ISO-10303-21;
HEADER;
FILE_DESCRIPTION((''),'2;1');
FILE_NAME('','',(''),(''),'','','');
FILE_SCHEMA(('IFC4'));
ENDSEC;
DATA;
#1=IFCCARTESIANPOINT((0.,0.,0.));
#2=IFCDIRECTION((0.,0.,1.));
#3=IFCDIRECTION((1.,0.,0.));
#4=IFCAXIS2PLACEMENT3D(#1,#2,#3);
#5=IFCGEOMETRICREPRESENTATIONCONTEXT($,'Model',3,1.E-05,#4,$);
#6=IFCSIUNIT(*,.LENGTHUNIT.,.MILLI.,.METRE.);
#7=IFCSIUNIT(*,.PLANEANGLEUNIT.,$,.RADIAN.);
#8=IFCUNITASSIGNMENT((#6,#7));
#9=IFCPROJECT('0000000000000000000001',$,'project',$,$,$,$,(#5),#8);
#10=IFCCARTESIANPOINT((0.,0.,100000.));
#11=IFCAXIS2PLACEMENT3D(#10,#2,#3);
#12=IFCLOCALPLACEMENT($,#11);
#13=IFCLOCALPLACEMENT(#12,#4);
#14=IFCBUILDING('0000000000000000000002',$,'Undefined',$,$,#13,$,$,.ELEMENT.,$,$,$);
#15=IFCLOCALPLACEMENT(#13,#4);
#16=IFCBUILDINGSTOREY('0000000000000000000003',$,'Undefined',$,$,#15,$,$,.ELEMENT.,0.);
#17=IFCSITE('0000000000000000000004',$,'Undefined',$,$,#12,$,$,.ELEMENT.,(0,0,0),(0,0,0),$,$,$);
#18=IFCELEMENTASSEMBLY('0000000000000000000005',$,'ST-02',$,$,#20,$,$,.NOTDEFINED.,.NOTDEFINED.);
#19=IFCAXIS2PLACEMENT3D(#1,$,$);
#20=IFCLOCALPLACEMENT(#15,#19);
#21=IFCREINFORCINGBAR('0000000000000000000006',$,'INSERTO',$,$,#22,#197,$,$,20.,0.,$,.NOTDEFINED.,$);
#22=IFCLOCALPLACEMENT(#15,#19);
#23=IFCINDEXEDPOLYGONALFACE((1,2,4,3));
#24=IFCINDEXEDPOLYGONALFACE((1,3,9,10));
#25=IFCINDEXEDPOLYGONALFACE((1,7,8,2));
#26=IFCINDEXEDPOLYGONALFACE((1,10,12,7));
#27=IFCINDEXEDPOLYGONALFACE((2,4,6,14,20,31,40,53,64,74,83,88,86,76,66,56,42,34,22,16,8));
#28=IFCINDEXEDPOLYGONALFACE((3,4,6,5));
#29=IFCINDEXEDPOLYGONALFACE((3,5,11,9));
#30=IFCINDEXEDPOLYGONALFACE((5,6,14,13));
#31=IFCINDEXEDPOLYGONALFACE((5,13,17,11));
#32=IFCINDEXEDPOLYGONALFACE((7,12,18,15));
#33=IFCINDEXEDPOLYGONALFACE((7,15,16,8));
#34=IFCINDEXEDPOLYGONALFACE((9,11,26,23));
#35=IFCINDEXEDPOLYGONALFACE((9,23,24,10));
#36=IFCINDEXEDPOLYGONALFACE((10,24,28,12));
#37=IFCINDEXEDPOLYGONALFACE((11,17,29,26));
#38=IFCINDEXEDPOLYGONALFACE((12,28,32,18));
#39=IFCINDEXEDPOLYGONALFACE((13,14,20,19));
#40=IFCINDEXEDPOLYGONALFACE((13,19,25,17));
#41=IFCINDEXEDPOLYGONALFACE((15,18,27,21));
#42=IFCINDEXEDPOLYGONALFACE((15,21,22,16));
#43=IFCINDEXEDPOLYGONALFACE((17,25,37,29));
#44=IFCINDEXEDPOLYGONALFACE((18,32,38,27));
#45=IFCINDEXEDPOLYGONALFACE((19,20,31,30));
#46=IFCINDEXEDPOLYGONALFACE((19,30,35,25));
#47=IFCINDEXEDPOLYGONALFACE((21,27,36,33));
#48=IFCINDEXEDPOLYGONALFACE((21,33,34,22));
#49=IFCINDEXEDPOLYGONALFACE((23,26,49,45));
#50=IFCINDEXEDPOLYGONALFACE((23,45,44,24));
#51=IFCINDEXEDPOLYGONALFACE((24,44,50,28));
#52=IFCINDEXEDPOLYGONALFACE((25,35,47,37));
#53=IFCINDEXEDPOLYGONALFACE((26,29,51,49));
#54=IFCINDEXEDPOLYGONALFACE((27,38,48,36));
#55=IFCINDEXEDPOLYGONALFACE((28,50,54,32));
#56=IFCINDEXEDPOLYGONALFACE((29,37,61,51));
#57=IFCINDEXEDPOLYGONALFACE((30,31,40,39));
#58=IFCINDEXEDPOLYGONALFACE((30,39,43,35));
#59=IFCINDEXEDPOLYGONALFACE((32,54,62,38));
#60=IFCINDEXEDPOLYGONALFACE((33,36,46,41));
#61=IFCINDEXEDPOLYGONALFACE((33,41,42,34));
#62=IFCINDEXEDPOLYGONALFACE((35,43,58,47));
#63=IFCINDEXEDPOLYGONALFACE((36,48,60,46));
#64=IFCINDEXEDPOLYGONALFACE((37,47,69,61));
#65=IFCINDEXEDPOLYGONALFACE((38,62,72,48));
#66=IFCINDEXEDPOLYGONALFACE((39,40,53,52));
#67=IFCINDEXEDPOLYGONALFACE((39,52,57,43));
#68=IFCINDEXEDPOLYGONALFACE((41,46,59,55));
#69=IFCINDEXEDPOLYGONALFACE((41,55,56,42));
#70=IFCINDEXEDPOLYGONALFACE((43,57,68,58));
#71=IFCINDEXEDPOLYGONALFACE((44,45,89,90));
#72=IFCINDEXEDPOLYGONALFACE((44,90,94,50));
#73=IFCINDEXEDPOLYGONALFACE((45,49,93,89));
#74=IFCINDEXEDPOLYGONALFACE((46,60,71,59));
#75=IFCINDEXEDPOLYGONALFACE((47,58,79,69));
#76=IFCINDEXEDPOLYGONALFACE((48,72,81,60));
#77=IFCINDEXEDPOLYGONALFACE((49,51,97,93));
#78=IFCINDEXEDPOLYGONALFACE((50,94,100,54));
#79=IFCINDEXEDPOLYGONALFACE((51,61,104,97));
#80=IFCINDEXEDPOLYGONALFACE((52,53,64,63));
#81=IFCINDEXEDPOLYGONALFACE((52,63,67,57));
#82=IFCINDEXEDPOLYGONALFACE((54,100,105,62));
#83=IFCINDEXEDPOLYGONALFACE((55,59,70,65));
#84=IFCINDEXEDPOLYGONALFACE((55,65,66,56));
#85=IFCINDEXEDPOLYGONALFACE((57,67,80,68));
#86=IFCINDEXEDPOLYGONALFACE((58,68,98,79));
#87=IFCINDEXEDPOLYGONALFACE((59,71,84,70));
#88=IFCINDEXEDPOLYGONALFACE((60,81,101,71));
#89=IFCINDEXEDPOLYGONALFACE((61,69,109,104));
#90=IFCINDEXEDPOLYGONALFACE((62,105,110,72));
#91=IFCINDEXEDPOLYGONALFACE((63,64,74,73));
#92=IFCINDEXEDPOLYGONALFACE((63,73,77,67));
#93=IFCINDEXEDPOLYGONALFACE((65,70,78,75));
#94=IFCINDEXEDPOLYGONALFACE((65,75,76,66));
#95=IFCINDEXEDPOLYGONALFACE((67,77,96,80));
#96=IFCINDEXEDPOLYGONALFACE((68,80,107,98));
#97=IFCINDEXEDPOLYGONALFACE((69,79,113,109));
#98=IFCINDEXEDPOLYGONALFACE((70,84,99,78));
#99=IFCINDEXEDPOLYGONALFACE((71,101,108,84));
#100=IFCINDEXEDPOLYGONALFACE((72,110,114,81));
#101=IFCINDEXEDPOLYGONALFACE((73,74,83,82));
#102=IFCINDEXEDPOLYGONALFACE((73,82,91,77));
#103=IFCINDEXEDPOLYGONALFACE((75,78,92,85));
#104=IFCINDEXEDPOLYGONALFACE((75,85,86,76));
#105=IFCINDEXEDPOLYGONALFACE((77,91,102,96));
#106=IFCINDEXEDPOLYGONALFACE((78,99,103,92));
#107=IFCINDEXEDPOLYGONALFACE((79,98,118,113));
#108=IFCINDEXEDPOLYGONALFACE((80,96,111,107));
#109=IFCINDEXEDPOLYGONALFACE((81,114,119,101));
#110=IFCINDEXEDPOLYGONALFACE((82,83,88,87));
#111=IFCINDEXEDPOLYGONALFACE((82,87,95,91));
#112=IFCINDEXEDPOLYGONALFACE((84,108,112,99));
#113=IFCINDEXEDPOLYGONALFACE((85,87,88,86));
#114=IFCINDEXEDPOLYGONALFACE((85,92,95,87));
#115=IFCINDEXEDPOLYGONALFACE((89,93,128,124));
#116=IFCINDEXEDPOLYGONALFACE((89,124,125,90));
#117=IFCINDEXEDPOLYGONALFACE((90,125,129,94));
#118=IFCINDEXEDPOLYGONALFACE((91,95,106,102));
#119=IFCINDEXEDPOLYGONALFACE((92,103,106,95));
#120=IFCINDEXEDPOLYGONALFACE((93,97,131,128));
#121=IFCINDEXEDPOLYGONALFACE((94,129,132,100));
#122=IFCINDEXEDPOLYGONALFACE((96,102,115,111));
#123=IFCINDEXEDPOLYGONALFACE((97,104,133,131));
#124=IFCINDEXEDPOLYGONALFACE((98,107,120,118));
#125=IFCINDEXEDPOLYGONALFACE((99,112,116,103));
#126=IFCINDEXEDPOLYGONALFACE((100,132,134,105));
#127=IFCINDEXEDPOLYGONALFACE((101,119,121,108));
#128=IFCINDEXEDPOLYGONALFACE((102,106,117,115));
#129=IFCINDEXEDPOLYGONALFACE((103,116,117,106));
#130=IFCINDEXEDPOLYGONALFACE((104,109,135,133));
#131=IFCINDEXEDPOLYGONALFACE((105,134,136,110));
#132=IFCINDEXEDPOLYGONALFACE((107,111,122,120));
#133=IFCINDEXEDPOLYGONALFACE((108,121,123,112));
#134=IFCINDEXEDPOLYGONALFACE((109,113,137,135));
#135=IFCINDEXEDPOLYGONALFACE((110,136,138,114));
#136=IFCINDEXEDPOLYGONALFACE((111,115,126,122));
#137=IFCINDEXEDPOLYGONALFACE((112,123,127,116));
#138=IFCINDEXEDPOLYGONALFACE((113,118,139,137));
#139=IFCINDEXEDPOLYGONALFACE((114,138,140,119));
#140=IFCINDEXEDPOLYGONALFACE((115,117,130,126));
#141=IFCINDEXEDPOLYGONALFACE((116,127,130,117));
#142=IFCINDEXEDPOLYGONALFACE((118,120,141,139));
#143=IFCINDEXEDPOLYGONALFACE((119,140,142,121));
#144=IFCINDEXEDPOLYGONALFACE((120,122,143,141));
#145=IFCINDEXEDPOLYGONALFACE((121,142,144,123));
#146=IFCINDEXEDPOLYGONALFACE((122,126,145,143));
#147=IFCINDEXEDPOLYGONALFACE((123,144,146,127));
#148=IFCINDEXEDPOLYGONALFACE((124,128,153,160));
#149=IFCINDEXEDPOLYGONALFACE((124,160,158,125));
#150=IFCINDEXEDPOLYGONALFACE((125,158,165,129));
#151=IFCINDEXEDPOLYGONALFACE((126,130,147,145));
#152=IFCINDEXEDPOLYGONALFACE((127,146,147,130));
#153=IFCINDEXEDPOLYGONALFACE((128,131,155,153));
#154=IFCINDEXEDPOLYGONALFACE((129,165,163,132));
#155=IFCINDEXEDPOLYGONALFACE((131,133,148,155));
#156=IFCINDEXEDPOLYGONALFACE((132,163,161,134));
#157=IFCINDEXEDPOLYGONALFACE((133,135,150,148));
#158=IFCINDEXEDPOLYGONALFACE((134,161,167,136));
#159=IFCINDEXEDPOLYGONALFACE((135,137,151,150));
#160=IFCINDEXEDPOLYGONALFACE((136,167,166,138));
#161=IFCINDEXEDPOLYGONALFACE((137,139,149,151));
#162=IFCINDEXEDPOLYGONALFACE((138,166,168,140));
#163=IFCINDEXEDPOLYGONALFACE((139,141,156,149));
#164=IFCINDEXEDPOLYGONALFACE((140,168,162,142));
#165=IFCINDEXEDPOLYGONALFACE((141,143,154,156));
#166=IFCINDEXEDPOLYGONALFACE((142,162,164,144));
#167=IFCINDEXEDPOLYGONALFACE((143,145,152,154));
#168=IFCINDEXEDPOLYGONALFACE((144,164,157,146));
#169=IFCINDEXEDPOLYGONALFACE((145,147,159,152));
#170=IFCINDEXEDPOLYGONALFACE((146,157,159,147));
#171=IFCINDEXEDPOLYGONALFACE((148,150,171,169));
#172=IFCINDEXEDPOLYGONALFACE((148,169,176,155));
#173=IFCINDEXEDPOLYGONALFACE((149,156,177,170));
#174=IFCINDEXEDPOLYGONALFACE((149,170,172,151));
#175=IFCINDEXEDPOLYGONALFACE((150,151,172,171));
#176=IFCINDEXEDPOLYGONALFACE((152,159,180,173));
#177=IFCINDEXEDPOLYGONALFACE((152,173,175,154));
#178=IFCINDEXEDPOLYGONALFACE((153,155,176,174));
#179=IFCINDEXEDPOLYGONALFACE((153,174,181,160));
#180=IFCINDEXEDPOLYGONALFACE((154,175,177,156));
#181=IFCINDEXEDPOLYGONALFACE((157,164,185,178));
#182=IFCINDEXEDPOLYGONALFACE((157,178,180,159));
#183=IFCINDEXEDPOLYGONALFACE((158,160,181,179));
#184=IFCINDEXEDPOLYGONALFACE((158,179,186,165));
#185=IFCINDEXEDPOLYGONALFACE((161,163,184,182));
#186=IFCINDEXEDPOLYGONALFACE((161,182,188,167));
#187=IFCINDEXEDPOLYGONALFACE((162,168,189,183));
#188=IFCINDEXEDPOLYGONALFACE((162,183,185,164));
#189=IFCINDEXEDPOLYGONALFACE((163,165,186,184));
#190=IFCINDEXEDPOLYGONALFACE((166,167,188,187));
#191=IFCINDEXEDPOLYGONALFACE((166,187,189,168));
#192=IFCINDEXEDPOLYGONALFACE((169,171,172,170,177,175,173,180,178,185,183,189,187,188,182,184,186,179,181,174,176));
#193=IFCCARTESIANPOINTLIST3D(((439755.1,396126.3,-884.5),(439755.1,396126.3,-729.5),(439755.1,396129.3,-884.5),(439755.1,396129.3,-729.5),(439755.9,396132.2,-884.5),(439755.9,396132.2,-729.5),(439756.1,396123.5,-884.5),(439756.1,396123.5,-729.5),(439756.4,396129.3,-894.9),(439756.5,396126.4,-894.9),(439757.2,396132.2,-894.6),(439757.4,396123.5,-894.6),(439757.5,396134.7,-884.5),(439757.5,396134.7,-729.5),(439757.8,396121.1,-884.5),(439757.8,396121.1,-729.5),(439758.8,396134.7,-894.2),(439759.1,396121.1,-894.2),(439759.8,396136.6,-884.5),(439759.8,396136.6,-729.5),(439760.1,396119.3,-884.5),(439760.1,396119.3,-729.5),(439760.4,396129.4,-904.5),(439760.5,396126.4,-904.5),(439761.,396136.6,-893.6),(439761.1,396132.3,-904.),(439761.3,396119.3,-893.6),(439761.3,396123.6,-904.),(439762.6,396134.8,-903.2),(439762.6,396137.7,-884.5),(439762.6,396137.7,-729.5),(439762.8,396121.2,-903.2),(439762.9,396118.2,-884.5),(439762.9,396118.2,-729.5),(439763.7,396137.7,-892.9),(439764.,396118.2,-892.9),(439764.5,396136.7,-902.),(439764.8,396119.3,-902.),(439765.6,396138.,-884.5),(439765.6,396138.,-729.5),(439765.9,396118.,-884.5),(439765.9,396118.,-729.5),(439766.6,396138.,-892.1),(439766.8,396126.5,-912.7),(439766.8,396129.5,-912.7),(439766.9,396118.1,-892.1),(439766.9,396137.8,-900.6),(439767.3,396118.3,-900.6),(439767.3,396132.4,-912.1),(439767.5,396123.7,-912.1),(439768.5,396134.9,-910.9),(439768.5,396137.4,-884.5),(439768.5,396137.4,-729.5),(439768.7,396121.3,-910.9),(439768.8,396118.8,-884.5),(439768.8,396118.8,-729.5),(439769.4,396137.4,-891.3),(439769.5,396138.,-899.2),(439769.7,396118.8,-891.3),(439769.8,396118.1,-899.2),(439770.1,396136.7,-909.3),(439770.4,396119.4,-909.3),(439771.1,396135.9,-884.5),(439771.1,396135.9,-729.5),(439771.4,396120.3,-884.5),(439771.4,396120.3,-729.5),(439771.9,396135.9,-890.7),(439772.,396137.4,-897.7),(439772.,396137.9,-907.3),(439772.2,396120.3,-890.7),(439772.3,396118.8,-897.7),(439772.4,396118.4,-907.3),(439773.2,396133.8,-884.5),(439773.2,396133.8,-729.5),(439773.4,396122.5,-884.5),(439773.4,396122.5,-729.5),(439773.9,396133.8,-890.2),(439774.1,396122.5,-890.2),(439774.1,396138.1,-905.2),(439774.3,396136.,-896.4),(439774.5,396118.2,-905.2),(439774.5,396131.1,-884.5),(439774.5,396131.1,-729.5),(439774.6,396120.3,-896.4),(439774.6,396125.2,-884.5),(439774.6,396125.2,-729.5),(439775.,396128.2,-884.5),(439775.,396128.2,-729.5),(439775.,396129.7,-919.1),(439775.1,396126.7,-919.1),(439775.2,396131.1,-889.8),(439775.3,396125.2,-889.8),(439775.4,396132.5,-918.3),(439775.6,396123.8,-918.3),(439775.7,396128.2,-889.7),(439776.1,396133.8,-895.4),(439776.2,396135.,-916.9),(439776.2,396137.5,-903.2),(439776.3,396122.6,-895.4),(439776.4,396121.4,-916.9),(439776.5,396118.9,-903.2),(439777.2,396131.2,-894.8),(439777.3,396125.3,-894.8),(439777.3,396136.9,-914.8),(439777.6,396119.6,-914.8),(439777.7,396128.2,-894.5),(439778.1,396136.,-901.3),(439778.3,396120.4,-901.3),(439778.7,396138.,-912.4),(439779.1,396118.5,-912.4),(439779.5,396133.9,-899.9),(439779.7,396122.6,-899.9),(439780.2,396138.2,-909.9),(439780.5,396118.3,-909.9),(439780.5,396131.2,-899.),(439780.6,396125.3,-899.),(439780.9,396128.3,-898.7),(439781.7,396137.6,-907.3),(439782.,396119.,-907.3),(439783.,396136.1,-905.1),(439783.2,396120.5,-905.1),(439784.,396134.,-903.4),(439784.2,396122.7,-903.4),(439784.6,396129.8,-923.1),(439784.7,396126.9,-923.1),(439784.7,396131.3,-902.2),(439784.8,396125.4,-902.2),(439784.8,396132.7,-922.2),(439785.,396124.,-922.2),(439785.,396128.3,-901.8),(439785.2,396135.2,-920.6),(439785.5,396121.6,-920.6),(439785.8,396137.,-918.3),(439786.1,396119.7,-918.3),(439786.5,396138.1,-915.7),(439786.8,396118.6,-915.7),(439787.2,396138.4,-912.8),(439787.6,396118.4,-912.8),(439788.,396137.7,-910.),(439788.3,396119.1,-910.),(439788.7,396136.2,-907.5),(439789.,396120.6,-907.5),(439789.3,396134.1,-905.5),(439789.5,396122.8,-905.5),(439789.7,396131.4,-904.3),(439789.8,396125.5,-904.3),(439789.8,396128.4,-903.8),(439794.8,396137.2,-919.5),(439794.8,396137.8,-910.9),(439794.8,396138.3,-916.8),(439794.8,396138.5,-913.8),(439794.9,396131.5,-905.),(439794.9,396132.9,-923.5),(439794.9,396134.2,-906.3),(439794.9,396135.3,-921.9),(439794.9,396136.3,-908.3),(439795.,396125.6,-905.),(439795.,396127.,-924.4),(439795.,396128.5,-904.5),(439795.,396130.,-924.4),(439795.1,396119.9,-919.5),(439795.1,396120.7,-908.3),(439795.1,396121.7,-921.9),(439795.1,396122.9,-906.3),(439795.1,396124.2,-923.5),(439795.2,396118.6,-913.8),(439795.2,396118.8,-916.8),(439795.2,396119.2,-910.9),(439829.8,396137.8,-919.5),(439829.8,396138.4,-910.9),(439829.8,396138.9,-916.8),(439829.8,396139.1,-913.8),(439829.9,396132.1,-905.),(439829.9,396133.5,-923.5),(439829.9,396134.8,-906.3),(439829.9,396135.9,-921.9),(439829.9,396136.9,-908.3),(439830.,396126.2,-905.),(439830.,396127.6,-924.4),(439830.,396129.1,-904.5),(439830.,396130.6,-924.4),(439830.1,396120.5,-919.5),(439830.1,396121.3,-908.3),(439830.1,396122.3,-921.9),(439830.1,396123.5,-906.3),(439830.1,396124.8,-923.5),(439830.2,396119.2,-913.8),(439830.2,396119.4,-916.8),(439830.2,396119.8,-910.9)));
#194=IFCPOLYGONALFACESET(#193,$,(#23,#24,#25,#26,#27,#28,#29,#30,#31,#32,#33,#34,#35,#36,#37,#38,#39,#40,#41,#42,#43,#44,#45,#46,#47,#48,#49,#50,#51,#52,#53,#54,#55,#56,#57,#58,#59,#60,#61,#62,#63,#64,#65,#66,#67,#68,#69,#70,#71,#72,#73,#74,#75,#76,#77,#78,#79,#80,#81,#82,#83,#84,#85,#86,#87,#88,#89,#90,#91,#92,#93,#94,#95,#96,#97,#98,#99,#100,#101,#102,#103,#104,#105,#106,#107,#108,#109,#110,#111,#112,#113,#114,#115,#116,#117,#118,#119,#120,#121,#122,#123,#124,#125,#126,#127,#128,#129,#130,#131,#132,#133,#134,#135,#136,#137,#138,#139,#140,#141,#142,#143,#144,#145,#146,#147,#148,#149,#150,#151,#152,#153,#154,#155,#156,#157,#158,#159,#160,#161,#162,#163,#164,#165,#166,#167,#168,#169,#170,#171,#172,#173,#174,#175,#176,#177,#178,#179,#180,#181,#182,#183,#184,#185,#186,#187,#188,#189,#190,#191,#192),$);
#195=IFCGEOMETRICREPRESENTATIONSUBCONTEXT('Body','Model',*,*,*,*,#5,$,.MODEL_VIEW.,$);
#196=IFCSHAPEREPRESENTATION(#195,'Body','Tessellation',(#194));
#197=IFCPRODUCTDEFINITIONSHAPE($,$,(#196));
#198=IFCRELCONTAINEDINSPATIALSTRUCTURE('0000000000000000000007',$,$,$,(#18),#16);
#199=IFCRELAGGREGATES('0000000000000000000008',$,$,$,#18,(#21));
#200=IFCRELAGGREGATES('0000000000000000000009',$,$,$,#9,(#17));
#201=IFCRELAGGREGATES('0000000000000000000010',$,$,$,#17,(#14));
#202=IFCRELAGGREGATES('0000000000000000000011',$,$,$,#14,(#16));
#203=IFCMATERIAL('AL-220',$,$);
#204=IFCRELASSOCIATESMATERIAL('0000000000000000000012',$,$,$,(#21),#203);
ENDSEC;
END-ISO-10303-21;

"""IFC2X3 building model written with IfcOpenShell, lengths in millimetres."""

from ifc_helpers import new_model, entity, si_unit, frame, origin_with_axes, place, context, subcontext, project, spatial, source, transform, mapped, material, element, aggregate, save


model = new_model("IFC2X3")

# Units and contexts
model_context = context("Model", 3, precision=1e-05, world=origin_with_axes())
body_context = subcontext(model_context, "Body", "Model", "MODEL_VIEW")
ifc_project = project(units=[si_unit("LENGTHUNIT", "METRE", prefix="MILLI"), si_unit("PLANEANGLEUNIT", "RADIAN")], contexts=[model_context])

# Site, building, storey
site_placement = place(None, frame((0.0, 0.0, 100000.0), z_axis=(0.0, 0.0, 1.0), x_axis=(1.0, 0.0, 0.0)))
site = spatial("IfcSite", under=ifc_project, at=site_placement, Name="Undefined", CompositionType="ELEMENT", RefLatitude=(0, 0, 0), RefLongitude=(0, 0, 0))
building_placement = place(site_placement, origin_with_axes())
building = spatial("IfcBuilding", under=site, at=building_placement, Name="Undefined", CompositionType="ELEMENT")
storey_placement = place(building_placement, origin_with_axes())
storey = spatial("IfcBuildingStorey", under=building, at=storey_placement, Name="Undefined", CompositionType="ELEMENT", Elevation=0.0)

# Element assembly
assembly_1_placement = place(storey_placement, origin_with_axes())
assembly_1 = element("IfcElementAssembly", 1, at=assembly_1_placement, inside=storey, Name="ST-02", AssemblyPlace="NOTDEFINED", PredefinedType="NOTDEFINED")

# Reinforcing bar
ifc_material_1 = material(Name="AL-220")
shared_shape_1 = source(origin_with_axes(), body_context, "Body", "AdvancedSweptSolid", [
    entity("IfcSweptDiskSolid", entity("IfcCompositeCurve", [entity("IfcCompositeCurveSegment", "CONTINUOUS", True, entity("IfcTrimmedCurve", entity("IfcLine", entity("IfcCartesianPoint", [0.0, 0.0, 0.0]), entity("IfcVector", entity("IfcDirection", [1.0, 0.0, 0.0]), 1.0)), [entity("IfcParameterValue", 0.0)], [entity("IfcParameterValue", 155.0)], True, "PARAMETER")), entity("IfcCompositeCurveSegment", "CONTINUOUS", True, entity("IfcTrimmedCurve", entity("IfcCircle", entity("IfcAxis2Placement3D", entity("IfcCartesianPoint", [155.0, 0.0, 30.0]), entity("IfcDirection", [0.0, -1.0, 0.0]), entity("IfcDirection", [0.0, 0.0, -1.0])), 30.0), [entity("IfcParameterValue", 0.0)], [entity("IfcParameterValue", 1.570796)], True, "PARAMETER")), entity("IfcCompositeCurveSegment", "DISCONTINUOUS", True, entity("IfcTrimmedCurve", entity("IfcLine", entity("IfcCartesianPoint", [185.0, 0.0, 30.0]), entity("IfcVector", entity("IfcDirection", [0.0, 0.0, 1.0]), 1.0)), [entity("IfcParameterValue", 0.0)], [entity("IfcParameterValue", 35.0)], True, "PARAMETER"))], False), 10.0, None, 0.0, 191.6),
])
reinforcing_bar_1_placement = place(assembly_1_placement, frame((439765.0, 396128.0, -729.5), z_axis=(0.999848, 0.017452, 0.0), x_axis=(0.0, 0.0, -1.0)))
reinforcing_bar_1 = element("IfcReinforcingBar", 2, at=reinforcing_bar_1_placement, material=ifc_material_1, Name="INSERTO", BarRole="NOTDEFINED", CrossSectionArea=0.0, NominalDiameter=20.0, context=body_context, shape_type="MappedRepresentation", body=[
    mapped(shared_shape_1, transform((0.0, 0.0, 0.0))),
])
aggregate(assembly_1, [reinforcing_bar_1])

save(model, "model.ifc")
